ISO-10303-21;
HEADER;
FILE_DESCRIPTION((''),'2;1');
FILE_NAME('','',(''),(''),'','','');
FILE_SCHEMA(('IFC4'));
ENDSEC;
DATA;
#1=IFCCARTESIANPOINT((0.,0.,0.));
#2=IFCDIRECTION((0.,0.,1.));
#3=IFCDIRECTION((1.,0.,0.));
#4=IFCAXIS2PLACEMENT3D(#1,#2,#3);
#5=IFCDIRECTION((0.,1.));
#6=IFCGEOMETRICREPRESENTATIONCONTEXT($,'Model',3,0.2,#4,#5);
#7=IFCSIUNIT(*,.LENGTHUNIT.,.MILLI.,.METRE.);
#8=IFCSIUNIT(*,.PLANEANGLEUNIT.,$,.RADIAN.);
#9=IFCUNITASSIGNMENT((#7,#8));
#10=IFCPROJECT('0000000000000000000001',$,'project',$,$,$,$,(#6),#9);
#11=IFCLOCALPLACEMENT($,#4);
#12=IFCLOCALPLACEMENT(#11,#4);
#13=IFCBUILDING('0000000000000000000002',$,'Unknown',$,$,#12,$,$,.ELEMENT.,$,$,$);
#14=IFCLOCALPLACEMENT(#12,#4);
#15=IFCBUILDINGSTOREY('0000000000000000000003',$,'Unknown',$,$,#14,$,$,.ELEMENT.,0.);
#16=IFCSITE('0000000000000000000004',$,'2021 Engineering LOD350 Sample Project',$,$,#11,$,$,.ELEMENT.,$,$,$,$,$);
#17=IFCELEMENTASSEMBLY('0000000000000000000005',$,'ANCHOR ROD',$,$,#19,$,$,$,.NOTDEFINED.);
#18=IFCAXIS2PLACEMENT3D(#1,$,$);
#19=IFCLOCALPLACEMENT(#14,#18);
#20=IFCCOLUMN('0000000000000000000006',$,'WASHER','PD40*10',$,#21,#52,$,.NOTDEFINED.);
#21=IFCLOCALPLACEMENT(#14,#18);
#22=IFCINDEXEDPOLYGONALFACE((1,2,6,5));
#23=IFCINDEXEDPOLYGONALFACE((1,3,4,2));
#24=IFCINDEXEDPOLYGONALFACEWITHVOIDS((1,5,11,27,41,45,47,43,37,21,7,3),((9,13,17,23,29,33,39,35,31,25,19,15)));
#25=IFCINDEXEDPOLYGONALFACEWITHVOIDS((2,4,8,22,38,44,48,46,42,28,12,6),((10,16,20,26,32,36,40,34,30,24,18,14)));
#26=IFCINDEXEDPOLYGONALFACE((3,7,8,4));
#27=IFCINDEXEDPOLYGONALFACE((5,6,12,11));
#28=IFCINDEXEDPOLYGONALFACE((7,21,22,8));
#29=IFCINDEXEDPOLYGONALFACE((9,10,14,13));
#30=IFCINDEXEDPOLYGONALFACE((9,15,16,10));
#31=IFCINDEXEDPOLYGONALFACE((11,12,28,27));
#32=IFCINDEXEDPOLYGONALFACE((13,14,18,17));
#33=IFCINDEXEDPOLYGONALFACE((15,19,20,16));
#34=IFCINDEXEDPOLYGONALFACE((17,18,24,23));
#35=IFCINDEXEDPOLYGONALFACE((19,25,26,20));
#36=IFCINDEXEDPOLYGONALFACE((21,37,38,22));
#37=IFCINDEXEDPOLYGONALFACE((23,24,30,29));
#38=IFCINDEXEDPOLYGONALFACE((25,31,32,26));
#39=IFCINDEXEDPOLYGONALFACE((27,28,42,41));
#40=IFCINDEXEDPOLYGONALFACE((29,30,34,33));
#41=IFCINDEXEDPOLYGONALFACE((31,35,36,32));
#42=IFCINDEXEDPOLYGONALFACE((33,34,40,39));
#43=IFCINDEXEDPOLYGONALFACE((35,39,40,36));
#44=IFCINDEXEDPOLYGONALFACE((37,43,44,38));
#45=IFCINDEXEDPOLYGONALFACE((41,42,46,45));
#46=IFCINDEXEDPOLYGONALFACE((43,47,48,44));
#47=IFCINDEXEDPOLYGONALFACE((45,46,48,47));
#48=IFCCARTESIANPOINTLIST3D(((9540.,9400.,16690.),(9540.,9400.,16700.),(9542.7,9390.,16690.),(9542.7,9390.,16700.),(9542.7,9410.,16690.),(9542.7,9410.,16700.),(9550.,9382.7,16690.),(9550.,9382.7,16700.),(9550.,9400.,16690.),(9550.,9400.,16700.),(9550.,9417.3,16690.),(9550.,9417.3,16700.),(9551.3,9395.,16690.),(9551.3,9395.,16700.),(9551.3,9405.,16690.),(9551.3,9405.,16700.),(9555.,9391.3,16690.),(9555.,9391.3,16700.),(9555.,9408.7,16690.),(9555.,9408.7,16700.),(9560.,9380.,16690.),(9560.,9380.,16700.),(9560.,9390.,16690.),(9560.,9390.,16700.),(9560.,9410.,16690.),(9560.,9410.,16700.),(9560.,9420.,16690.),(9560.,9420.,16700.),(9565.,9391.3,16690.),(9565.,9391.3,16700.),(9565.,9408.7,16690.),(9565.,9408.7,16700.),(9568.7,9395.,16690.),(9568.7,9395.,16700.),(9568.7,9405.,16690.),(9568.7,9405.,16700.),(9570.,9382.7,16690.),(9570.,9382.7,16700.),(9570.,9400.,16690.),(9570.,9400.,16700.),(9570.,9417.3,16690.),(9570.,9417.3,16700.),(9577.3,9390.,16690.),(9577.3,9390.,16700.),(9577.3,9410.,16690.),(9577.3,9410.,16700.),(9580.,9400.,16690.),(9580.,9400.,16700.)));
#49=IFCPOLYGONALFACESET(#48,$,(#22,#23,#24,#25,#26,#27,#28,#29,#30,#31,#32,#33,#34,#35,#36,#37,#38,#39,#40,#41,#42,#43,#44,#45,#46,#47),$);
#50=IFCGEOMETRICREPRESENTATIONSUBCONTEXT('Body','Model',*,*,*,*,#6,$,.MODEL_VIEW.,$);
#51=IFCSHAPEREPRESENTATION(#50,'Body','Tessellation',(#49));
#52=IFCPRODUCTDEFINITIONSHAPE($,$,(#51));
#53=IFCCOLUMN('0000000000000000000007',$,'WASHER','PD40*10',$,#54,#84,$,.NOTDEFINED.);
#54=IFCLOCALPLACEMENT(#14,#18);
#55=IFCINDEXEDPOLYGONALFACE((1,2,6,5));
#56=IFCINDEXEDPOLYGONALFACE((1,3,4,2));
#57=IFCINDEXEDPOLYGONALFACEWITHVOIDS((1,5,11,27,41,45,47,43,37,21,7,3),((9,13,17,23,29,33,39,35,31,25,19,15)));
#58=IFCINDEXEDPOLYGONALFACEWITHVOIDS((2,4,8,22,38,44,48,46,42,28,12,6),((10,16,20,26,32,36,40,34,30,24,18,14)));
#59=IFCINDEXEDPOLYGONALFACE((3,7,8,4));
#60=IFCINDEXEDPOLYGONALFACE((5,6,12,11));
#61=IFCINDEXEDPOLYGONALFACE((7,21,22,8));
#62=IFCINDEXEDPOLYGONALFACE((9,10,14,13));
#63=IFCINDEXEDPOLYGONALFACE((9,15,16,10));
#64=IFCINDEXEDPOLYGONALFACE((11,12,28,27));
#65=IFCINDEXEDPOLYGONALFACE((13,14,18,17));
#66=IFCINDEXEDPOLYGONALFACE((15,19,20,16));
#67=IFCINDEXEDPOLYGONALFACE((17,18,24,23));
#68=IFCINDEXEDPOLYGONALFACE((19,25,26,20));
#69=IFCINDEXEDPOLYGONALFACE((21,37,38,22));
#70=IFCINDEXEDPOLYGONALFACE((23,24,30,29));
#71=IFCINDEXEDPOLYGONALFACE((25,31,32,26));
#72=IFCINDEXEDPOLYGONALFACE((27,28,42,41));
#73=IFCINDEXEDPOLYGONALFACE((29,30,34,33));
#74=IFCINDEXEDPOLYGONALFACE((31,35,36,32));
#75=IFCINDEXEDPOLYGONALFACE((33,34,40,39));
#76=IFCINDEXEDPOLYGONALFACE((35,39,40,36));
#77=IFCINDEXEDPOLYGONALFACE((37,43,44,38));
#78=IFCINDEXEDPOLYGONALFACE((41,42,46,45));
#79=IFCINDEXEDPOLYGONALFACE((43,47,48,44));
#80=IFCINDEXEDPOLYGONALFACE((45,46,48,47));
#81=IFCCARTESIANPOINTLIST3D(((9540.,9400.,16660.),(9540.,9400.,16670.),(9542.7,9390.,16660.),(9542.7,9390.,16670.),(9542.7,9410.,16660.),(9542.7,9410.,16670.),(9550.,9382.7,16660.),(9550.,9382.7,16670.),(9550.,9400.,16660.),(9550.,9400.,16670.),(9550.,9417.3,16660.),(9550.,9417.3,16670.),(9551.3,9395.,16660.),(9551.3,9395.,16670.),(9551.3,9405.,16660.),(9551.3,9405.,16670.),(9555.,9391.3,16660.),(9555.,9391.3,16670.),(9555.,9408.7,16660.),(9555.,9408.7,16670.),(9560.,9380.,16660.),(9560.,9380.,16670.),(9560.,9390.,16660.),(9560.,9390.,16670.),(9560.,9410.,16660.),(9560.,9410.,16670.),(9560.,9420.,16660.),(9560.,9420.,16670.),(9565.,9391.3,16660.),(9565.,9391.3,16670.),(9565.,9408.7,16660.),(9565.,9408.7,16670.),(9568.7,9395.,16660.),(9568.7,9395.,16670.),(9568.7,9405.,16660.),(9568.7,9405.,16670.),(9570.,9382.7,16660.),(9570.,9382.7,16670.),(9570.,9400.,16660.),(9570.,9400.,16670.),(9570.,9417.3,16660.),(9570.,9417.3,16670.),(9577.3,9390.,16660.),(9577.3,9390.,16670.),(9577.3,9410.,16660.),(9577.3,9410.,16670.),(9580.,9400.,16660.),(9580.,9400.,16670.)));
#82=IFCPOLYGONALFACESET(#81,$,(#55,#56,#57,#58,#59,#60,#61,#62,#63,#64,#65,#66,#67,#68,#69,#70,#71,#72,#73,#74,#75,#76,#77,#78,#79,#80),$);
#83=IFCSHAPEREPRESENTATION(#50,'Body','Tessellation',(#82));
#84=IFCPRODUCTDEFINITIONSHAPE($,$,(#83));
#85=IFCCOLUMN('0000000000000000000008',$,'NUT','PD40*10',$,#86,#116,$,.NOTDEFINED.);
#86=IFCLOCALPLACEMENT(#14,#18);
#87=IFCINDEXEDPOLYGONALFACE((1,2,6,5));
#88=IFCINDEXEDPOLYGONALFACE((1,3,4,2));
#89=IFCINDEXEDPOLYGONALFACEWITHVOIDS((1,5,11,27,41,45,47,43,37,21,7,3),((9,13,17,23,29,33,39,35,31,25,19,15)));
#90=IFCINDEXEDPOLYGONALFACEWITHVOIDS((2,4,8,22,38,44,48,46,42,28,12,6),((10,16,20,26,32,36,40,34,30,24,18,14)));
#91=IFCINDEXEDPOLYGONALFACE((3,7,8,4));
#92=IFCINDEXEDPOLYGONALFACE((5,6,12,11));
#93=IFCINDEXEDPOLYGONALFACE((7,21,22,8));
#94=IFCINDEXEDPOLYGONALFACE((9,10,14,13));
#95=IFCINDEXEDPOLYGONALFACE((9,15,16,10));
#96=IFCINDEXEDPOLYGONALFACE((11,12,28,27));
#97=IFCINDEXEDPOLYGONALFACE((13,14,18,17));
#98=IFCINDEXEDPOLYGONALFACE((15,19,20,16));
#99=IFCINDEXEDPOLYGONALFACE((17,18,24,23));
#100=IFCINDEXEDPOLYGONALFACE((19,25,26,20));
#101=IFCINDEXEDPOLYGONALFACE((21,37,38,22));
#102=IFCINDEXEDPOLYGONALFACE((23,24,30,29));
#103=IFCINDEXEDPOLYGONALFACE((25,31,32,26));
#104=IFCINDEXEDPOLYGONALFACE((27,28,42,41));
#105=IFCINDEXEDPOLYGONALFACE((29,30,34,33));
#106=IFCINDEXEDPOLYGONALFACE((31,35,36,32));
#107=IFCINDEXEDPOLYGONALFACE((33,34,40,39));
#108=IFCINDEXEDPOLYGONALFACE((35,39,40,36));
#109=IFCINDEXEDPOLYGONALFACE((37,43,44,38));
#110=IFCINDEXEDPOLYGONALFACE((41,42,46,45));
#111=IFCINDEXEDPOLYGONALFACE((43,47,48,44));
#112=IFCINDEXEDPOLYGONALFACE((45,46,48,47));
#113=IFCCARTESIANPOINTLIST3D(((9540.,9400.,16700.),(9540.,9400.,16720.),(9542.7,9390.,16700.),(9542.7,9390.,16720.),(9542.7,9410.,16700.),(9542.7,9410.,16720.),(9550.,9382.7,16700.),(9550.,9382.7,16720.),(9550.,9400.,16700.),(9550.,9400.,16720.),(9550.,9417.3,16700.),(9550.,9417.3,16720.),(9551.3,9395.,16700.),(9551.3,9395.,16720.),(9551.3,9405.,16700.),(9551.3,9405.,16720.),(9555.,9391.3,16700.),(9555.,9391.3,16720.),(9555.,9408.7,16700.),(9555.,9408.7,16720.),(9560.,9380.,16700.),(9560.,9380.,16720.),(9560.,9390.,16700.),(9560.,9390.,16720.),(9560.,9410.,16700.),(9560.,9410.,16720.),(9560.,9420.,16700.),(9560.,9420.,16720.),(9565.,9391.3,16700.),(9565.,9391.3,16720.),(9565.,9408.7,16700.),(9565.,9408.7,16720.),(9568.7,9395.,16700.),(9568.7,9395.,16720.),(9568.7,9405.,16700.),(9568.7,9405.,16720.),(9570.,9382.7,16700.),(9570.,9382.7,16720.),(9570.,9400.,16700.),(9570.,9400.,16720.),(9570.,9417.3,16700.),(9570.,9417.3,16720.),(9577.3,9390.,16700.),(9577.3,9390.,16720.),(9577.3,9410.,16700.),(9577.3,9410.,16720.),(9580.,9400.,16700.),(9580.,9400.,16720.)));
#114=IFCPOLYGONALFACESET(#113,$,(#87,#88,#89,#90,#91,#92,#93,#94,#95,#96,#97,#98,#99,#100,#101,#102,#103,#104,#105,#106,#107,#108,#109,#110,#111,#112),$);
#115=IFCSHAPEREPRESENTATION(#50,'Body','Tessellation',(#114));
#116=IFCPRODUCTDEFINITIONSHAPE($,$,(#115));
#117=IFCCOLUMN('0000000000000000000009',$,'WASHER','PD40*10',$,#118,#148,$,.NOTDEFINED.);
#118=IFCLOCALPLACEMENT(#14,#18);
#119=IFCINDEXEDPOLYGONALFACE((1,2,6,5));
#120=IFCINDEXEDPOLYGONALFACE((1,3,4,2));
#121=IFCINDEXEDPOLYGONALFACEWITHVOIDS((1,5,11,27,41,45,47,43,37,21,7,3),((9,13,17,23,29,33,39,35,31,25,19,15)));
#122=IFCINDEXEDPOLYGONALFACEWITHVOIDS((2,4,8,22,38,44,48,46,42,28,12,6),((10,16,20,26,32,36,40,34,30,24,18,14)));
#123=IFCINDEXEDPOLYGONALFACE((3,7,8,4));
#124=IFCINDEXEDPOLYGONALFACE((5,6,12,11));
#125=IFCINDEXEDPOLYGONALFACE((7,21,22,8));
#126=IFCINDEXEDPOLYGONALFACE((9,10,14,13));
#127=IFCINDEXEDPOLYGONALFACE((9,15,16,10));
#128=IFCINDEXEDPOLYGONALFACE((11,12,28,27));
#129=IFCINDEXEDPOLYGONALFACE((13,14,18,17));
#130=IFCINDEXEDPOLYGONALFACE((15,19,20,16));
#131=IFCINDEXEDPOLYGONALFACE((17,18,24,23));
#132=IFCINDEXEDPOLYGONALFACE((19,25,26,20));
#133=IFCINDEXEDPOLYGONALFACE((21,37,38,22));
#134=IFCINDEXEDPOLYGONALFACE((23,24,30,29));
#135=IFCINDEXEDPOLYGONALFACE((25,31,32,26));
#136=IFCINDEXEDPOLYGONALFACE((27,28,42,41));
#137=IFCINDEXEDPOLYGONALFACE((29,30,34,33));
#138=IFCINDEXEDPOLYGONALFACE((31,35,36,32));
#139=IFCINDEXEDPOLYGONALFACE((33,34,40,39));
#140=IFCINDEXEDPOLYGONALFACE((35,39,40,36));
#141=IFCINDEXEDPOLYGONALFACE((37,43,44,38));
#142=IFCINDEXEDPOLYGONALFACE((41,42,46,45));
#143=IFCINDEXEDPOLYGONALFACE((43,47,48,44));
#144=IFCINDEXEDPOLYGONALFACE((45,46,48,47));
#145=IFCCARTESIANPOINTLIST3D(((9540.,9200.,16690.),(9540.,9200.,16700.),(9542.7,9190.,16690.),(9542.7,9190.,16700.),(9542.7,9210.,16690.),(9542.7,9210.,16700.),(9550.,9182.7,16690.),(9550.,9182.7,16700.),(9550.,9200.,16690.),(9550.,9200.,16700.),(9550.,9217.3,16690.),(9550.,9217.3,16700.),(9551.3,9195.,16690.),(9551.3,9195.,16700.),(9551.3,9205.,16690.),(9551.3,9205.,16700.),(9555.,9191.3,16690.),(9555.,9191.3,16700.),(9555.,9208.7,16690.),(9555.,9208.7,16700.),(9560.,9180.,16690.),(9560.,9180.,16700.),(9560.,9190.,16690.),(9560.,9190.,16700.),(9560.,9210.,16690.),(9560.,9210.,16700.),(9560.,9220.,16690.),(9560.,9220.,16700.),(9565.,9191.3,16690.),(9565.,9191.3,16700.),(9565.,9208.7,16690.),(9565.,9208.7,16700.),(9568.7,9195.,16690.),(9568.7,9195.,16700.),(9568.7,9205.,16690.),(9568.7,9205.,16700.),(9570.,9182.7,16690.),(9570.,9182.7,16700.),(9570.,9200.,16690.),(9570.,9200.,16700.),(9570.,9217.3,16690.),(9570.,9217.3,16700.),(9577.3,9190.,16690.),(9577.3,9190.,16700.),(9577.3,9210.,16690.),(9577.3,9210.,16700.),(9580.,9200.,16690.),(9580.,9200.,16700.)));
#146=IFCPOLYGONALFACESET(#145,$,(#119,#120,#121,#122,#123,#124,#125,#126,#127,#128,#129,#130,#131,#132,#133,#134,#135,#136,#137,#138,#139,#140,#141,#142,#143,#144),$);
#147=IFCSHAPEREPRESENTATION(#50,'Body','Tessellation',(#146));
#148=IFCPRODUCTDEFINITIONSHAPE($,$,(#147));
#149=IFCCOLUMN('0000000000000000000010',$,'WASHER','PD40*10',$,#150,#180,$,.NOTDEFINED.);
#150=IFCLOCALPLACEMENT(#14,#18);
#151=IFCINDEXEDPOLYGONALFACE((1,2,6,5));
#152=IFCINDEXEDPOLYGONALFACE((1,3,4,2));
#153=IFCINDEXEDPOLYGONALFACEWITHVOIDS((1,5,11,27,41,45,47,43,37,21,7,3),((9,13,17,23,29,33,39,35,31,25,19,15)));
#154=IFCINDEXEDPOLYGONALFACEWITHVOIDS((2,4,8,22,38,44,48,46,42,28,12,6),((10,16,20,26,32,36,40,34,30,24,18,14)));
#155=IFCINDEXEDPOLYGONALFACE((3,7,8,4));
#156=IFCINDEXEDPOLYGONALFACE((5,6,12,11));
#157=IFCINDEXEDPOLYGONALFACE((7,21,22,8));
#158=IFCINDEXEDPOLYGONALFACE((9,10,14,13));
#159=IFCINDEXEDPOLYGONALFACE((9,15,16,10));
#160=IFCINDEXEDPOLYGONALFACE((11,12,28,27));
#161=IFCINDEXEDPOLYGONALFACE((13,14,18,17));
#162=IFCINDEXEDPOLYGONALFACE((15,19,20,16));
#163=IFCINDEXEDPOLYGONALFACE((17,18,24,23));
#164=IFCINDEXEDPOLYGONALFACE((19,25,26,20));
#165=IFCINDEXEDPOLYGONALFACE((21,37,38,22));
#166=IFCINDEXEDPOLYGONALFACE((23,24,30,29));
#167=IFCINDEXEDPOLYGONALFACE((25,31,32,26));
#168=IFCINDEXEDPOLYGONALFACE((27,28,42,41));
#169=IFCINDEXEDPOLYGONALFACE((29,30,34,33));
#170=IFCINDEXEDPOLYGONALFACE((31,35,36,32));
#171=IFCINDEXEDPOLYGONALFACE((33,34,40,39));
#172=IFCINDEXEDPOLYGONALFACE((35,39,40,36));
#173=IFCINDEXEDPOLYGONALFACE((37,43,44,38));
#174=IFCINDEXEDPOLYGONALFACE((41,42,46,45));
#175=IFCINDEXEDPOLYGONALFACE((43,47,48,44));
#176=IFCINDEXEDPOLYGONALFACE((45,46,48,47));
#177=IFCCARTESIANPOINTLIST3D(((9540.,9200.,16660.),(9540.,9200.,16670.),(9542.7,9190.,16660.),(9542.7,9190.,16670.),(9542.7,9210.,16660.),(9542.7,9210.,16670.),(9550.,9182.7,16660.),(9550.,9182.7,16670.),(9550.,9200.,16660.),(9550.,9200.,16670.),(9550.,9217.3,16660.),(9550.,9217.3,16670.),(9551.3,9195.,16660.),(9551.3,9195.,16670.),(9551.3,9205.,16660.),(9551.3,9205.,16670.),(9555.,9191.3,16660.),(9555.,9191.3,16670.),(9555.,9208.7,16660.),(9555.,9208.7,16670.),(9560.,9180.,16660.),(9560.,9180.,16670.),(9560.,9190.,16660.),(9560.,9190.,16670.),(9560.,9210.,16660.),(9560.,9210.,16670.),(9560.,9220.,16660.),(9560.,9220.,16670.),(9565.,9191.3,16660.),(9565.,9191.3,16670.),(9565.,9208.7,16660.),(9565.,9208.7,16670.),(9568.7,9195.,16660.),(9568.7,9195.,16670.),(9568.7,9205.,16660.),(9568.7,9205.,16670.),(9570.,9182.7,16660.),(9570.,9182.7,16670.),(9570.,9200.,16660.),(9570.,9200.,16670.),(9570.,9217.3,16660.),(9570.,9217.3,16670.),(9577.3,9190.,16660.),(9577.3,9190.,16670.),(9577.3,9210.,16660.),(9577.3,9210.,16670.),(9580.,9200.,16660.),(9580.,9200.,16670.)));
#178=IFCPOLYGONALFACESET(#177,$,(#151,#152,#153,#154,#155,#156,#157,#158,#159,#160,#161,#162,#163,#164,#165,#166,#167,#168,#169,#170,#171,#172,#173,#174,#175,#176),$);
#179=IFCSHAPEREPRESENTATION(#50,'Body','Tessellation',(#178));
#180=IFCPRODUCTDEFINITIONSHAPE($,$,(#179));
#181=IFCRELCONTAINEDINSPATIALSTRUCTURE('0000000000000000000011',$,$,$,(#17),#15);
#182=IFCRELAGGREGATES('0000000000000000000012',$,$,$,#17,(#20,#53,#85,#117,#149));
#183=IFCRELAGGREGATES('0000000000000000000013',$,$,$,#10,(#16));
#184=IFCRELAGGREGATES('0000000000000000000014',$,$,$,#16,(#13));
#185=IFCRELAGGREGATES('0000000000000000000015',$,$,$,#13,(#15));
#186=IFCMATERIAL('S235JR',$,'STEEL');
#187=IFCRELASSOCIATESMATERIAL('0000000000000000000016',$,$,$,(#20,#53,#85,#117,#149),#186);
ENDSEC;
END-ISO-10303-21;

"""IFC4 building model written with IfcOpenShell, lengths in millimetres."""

from ifc_helpers import new_model, si_unit, direction, frame, origin_with_axes, place, context, subcontext, project, spatial, line, indexed_curve, outline, extrude, material, element, aggregate, save


model = new_model("IFC4")

# Units and contexts
model_context = context("Model", 3, precision=0.2, world=origin_with_axes(), true_north=direction((0.0, 1.0)))
body_context = subcontext(model_context, "Body", "Model", "MODEL_VIEW")
ifc_project = project(units=[si_unit("LENGTHUNIT", "METRE", prefix="MILLI"), si_unit("PLANEANGLEUNIT", "RADIAN")], contexts=[model_context])

# Site, building, storey
site_placement = place(None, origin_with_axes())
site = spatial("IfcSite", under=ifc_project, at=site_placement, Name="2021 Engineering LOD350 Sample Project", CompositionType="ELEMENT")
building_placement = place(site_placement, origin_with_axes())
building = spatial("IfcBuilding", under=site, at=building_placement, Name="Unknown", CompositionType="ELEMENT")
storey_placement = place(building_placement, origin_with_axes())
storey = spatial("IfcBuildingStorey", under=building, at=storey_placement, Name="Unknown", CompositionType="ELEMENT", Elevation=0.0)

# Shared definitions
ifc_material_1 = material(Name="S235JR", Category="STEEL")

# Element assembly, columns
assembly_1_placement = place(storey_placement, frame((9940.0, 9400.0, 16730.0), z_axis=(1.0, 0.0, 0.0), x_axis=(0.0, 0.0, -1.0)))
assembly_1 = element("IfcElementAssembly", 1, at=assembly_1_placement, inside=storey, Name="ANCHOR ROD", PredefinedType="NOTDEFINED")
column_1_placement = place(assembly_1_placement, frame((30.0, 0.0, -380.0), z_axis=(0.0, 0.0, -1.0), x_axis=(1.0, 0.0, 0.0)))
column_1 = element("IfcColumn", 2, at=column_1_placement, material=ifc_material_1, Name="WASHER", Description="PD40*10", PredefinedType="NOTDEFINED", context=body_context, shape_type="SolidModel", body=[
    extrude(outline(indexed_curve([(20.0, 0.0), (17.3, 10.0), (10.0, 17.3), (0.0, 20.0), (-10.0, 17.3), (-17.3, 10.0), (-20.0, 0.0), (-17.3, -10.0), (-10.0, -17.3), (0.0, -20.0), (10.0, -17.3), (17.3, -10.0)], segments=[line(1, 2, 3, 4, 5, 6, 7, 8, 9, 10, 11, 12, 1)]), holes=[indexed_curve([(10.0, 0.0), (8.7, -5.0), (5.0, -8.7), (0.0, -10.0), (-5.0, -8.7), (-8.7, -5.0), (-10.0, 0.0), (-8.7, 5.0), (-5.0, 8.7), (0.0, 10.0), (5.0, 8.7), (8.7, 5.0)], segments=[line(1, 2, 3, 4, 5, 6, 7, 8, 9, 10, 11, 12, 1)])]), frame((0.0, 0.0, 0.0), z_axis=(-1.0, 0.0, 0.0), x_axis=(0.0, 0.0, 1.0)), (0.0, 0.0, -1.0), 10.0),
])
column_2_placement = place(assembly_1_placement, frame((60.0, 0.0, -380.0), z_axis=(0.0, 0.0, -1.0), x_axis=(1.0, 0.0, 0.0)))
column_2 = element("IfcColumn", 3, at=column_2_placement, material=ifc_material_1, Name="WASHER", Description="PD40*10", PredefinedType="NOTDEFINED", context=body_context, shape_type="SolidModel", body=[
    extrude(outline(indexed_curve([(20.0, 0.0), (17.3, 10.0), (10.0, 17.3), (0.0, 20.0), (-10.0, 17.3), (-17.3, 10.0), (-20.0, 0.0), (-17.3, -10.0), (-10.0, -17.3), (0.0, -20.0), (10.0, -17.3), (17.3, -10.0)], segments=[line(1, 2, 3, 4, 5, 6, 7, 8, 9, 10, 11, 12, 1)]), holes=[indexed_curve([(10.0, 0.0), (8.7, -5.0), (5.0, -8.7), (0.0, -10.0), (-5.0, -8.7), (-8.7, -5.0), (-10.0, 0.0), (-8.7, 5.0), (-5.0, 8.7), (0.0, 10.0), (5.0, 8.7), (8.7, 5.0)], segments=[line(1, 2, 3, 4, 5, 6, 7, 8, 9, 10, 11, 12, 1)])]), frame((0.0, 0.0, 0.0), z_axis=(-1.0, 0.0, 0.0), x_axis=(0.0, 0.0, 1.0)), (0.0, 0.0, -1.0), 10.0),
])
column_3_placement = place(assembly_1_placement, frame((10.0, 0.0, -380.0), z_axis=(0.0, 0.0, -1.0), x_axis=(1.0, 0.0, 0.0)))
column_3 = element("IfcColumn", 4, at=column_3_placement, material=ifc_material_1, Name="NUT", Description="PD40*10", PredefinedType="NOTDEFINED", context=body_context, shape_type="SolidModel", body=[
    extrude(outline(indexed_curve([(20.0, 0.0), (17.3, 10.0), (10.0, 17.3), (0.0, 20.0), (-10.0, 17.3), (-17.3, 10.0), (-20.0, 0.0), (-17.3, -10.0), (-10.0, -17.3), (0.0, -20.0), (10.0, -17.3), (17.3, -10.0)], segments=[line(1, 2, 3, 4, 5, 6, 7, 8, 9, 10, 11, 12, 1)]), holes=[indexed_curve([(10.0, 0.0), (8.7, -5.0), (5.0, -8.7), (0.0, -10.0), (-5.0, -8.7), (-8.7, -5.0), (-10.0, 0.0), (-8.7, 5.0), (-5.0, 8.7), (0.0, 10.0), (5.0, 8.7), (8.7, 5.0)], segments=[line(1, 2, 3, 4, 5, 6, 7, 8, 9, 10, 11, 12, 1)])]), frame((0.0, 0.0, 0.0), z_axis=(-1.0, 0.0, 0.0), x_axis=(0.0, 0.0, 1.0)), (0.0, 0.0, -1.0), 20.0),
])
column_4_placement = place(assembly_1_placement, frame((30.0, -200.0, -380.0), z_axis=(0.0, 0.0, -1.0), x_axis=(1.0, 0.0, 0.0)))
column_4 = element("IfcColumn", 5, at=column_4_placement, material=ifc_material_1, Name="WASHER", Description="PD40*10", PredefinedType="NOTDEFINED", context=body_context, shape_type="SolidModel", body=[
    extrude(outline(indexed_curve([(20.0, 0.0), (17.3, 10.0), (10.0, 17.3), (0.0, 20.0), (-10.0, 17.3), (-17.3, 10.0), (-20.0, 0.0), (-17.3, -10.0), (-10.0, -17.3), (0.0, -20.0), (10.0, -17.3), (17.3, -10.0)], segments=[line(1, 2, 3, 4, 5, 6, 7, 8, 9, 10, 11, 12, 1)]), holes=[indexed_curve([(10.0, 0.0), (8.7, -5.0), (5.0, -8.7), (0.0, -10.0), (-5.0, -8.7), (-8.7, -5.0), (-10.0, 0.0), (-8.7, 5.0), (-5.0, 8.7), (0.0, 10.0), (5.0, 8.7), (8.7, 5.0)], segments=[line(1, 2, 3, 4, 5, 6, 7, 8, 9, 10, 11, 12, 1)])]), frame((0.0, 0.0, 0.0), z_axis=(-1.0, 0.0, 0.0), x_axis=(0.0, 0.0, 1.0)), (0.0, 0.0, -1.0), 10.0),
])
column_5_placement = place(assembly_1_placement, frame((60.0, -200.0, -380.0), z_axis=(0.0, 0.0, -1.0), x_axis=(1.0, 0.0, 0.0)))
column_5 = element("IfcColumn", 6, at=column_5_placement, material=ifc_material_1, Name="WASHER", Description="PD40*10", PredefinedType="NOTDEFINED", context=body_context, shape_type="SolidModel", body=[
    extrude(outline(indexed_curve([(20.0, 0.0), (17.3, 10.0), (10.0, 17.3), (0.0, 20.0), (-10.0, 17.3), (-17.3, 10.0), (-20.0, 0.0), (-17.3, -10.0), (-10.0, -17.3), (0.0, -20.0), (10.0, -17.3), (17.3, -10.0)], segments=[line(1, 2, 3, 4, 5, 6, 7, 8, 9, 10, 11, 12, 1)]), holes=[indexed_curve([(10.0, 0.0), (8.7, -5.0), (5.0, -8.7), (0.0, -10.0), (-5.0, -8.7), (-8.7, -5.0), (-10.0, 0.0), (-8.7, 5.0), (-5.0, 8.7), (0.0, 10.0), (5.0, 8.7), (8.7, 5.0)], segments=[line(1, 2, 3, 4, 5, 6, 7, 8, 9, 10, 11, 12, 1)])]), frame((0.0, 0.0, 0.0), z_axis=(-1.0, 0.0, 0.0), x_axis=(0.0, 0.0, 1.0)), (0.0, 0.0, -1.0), 10.0),
])

aggregate(assembly_1, [column_1, column_2, column_3, column_4, column_5])

save(model, "model.ifc")
